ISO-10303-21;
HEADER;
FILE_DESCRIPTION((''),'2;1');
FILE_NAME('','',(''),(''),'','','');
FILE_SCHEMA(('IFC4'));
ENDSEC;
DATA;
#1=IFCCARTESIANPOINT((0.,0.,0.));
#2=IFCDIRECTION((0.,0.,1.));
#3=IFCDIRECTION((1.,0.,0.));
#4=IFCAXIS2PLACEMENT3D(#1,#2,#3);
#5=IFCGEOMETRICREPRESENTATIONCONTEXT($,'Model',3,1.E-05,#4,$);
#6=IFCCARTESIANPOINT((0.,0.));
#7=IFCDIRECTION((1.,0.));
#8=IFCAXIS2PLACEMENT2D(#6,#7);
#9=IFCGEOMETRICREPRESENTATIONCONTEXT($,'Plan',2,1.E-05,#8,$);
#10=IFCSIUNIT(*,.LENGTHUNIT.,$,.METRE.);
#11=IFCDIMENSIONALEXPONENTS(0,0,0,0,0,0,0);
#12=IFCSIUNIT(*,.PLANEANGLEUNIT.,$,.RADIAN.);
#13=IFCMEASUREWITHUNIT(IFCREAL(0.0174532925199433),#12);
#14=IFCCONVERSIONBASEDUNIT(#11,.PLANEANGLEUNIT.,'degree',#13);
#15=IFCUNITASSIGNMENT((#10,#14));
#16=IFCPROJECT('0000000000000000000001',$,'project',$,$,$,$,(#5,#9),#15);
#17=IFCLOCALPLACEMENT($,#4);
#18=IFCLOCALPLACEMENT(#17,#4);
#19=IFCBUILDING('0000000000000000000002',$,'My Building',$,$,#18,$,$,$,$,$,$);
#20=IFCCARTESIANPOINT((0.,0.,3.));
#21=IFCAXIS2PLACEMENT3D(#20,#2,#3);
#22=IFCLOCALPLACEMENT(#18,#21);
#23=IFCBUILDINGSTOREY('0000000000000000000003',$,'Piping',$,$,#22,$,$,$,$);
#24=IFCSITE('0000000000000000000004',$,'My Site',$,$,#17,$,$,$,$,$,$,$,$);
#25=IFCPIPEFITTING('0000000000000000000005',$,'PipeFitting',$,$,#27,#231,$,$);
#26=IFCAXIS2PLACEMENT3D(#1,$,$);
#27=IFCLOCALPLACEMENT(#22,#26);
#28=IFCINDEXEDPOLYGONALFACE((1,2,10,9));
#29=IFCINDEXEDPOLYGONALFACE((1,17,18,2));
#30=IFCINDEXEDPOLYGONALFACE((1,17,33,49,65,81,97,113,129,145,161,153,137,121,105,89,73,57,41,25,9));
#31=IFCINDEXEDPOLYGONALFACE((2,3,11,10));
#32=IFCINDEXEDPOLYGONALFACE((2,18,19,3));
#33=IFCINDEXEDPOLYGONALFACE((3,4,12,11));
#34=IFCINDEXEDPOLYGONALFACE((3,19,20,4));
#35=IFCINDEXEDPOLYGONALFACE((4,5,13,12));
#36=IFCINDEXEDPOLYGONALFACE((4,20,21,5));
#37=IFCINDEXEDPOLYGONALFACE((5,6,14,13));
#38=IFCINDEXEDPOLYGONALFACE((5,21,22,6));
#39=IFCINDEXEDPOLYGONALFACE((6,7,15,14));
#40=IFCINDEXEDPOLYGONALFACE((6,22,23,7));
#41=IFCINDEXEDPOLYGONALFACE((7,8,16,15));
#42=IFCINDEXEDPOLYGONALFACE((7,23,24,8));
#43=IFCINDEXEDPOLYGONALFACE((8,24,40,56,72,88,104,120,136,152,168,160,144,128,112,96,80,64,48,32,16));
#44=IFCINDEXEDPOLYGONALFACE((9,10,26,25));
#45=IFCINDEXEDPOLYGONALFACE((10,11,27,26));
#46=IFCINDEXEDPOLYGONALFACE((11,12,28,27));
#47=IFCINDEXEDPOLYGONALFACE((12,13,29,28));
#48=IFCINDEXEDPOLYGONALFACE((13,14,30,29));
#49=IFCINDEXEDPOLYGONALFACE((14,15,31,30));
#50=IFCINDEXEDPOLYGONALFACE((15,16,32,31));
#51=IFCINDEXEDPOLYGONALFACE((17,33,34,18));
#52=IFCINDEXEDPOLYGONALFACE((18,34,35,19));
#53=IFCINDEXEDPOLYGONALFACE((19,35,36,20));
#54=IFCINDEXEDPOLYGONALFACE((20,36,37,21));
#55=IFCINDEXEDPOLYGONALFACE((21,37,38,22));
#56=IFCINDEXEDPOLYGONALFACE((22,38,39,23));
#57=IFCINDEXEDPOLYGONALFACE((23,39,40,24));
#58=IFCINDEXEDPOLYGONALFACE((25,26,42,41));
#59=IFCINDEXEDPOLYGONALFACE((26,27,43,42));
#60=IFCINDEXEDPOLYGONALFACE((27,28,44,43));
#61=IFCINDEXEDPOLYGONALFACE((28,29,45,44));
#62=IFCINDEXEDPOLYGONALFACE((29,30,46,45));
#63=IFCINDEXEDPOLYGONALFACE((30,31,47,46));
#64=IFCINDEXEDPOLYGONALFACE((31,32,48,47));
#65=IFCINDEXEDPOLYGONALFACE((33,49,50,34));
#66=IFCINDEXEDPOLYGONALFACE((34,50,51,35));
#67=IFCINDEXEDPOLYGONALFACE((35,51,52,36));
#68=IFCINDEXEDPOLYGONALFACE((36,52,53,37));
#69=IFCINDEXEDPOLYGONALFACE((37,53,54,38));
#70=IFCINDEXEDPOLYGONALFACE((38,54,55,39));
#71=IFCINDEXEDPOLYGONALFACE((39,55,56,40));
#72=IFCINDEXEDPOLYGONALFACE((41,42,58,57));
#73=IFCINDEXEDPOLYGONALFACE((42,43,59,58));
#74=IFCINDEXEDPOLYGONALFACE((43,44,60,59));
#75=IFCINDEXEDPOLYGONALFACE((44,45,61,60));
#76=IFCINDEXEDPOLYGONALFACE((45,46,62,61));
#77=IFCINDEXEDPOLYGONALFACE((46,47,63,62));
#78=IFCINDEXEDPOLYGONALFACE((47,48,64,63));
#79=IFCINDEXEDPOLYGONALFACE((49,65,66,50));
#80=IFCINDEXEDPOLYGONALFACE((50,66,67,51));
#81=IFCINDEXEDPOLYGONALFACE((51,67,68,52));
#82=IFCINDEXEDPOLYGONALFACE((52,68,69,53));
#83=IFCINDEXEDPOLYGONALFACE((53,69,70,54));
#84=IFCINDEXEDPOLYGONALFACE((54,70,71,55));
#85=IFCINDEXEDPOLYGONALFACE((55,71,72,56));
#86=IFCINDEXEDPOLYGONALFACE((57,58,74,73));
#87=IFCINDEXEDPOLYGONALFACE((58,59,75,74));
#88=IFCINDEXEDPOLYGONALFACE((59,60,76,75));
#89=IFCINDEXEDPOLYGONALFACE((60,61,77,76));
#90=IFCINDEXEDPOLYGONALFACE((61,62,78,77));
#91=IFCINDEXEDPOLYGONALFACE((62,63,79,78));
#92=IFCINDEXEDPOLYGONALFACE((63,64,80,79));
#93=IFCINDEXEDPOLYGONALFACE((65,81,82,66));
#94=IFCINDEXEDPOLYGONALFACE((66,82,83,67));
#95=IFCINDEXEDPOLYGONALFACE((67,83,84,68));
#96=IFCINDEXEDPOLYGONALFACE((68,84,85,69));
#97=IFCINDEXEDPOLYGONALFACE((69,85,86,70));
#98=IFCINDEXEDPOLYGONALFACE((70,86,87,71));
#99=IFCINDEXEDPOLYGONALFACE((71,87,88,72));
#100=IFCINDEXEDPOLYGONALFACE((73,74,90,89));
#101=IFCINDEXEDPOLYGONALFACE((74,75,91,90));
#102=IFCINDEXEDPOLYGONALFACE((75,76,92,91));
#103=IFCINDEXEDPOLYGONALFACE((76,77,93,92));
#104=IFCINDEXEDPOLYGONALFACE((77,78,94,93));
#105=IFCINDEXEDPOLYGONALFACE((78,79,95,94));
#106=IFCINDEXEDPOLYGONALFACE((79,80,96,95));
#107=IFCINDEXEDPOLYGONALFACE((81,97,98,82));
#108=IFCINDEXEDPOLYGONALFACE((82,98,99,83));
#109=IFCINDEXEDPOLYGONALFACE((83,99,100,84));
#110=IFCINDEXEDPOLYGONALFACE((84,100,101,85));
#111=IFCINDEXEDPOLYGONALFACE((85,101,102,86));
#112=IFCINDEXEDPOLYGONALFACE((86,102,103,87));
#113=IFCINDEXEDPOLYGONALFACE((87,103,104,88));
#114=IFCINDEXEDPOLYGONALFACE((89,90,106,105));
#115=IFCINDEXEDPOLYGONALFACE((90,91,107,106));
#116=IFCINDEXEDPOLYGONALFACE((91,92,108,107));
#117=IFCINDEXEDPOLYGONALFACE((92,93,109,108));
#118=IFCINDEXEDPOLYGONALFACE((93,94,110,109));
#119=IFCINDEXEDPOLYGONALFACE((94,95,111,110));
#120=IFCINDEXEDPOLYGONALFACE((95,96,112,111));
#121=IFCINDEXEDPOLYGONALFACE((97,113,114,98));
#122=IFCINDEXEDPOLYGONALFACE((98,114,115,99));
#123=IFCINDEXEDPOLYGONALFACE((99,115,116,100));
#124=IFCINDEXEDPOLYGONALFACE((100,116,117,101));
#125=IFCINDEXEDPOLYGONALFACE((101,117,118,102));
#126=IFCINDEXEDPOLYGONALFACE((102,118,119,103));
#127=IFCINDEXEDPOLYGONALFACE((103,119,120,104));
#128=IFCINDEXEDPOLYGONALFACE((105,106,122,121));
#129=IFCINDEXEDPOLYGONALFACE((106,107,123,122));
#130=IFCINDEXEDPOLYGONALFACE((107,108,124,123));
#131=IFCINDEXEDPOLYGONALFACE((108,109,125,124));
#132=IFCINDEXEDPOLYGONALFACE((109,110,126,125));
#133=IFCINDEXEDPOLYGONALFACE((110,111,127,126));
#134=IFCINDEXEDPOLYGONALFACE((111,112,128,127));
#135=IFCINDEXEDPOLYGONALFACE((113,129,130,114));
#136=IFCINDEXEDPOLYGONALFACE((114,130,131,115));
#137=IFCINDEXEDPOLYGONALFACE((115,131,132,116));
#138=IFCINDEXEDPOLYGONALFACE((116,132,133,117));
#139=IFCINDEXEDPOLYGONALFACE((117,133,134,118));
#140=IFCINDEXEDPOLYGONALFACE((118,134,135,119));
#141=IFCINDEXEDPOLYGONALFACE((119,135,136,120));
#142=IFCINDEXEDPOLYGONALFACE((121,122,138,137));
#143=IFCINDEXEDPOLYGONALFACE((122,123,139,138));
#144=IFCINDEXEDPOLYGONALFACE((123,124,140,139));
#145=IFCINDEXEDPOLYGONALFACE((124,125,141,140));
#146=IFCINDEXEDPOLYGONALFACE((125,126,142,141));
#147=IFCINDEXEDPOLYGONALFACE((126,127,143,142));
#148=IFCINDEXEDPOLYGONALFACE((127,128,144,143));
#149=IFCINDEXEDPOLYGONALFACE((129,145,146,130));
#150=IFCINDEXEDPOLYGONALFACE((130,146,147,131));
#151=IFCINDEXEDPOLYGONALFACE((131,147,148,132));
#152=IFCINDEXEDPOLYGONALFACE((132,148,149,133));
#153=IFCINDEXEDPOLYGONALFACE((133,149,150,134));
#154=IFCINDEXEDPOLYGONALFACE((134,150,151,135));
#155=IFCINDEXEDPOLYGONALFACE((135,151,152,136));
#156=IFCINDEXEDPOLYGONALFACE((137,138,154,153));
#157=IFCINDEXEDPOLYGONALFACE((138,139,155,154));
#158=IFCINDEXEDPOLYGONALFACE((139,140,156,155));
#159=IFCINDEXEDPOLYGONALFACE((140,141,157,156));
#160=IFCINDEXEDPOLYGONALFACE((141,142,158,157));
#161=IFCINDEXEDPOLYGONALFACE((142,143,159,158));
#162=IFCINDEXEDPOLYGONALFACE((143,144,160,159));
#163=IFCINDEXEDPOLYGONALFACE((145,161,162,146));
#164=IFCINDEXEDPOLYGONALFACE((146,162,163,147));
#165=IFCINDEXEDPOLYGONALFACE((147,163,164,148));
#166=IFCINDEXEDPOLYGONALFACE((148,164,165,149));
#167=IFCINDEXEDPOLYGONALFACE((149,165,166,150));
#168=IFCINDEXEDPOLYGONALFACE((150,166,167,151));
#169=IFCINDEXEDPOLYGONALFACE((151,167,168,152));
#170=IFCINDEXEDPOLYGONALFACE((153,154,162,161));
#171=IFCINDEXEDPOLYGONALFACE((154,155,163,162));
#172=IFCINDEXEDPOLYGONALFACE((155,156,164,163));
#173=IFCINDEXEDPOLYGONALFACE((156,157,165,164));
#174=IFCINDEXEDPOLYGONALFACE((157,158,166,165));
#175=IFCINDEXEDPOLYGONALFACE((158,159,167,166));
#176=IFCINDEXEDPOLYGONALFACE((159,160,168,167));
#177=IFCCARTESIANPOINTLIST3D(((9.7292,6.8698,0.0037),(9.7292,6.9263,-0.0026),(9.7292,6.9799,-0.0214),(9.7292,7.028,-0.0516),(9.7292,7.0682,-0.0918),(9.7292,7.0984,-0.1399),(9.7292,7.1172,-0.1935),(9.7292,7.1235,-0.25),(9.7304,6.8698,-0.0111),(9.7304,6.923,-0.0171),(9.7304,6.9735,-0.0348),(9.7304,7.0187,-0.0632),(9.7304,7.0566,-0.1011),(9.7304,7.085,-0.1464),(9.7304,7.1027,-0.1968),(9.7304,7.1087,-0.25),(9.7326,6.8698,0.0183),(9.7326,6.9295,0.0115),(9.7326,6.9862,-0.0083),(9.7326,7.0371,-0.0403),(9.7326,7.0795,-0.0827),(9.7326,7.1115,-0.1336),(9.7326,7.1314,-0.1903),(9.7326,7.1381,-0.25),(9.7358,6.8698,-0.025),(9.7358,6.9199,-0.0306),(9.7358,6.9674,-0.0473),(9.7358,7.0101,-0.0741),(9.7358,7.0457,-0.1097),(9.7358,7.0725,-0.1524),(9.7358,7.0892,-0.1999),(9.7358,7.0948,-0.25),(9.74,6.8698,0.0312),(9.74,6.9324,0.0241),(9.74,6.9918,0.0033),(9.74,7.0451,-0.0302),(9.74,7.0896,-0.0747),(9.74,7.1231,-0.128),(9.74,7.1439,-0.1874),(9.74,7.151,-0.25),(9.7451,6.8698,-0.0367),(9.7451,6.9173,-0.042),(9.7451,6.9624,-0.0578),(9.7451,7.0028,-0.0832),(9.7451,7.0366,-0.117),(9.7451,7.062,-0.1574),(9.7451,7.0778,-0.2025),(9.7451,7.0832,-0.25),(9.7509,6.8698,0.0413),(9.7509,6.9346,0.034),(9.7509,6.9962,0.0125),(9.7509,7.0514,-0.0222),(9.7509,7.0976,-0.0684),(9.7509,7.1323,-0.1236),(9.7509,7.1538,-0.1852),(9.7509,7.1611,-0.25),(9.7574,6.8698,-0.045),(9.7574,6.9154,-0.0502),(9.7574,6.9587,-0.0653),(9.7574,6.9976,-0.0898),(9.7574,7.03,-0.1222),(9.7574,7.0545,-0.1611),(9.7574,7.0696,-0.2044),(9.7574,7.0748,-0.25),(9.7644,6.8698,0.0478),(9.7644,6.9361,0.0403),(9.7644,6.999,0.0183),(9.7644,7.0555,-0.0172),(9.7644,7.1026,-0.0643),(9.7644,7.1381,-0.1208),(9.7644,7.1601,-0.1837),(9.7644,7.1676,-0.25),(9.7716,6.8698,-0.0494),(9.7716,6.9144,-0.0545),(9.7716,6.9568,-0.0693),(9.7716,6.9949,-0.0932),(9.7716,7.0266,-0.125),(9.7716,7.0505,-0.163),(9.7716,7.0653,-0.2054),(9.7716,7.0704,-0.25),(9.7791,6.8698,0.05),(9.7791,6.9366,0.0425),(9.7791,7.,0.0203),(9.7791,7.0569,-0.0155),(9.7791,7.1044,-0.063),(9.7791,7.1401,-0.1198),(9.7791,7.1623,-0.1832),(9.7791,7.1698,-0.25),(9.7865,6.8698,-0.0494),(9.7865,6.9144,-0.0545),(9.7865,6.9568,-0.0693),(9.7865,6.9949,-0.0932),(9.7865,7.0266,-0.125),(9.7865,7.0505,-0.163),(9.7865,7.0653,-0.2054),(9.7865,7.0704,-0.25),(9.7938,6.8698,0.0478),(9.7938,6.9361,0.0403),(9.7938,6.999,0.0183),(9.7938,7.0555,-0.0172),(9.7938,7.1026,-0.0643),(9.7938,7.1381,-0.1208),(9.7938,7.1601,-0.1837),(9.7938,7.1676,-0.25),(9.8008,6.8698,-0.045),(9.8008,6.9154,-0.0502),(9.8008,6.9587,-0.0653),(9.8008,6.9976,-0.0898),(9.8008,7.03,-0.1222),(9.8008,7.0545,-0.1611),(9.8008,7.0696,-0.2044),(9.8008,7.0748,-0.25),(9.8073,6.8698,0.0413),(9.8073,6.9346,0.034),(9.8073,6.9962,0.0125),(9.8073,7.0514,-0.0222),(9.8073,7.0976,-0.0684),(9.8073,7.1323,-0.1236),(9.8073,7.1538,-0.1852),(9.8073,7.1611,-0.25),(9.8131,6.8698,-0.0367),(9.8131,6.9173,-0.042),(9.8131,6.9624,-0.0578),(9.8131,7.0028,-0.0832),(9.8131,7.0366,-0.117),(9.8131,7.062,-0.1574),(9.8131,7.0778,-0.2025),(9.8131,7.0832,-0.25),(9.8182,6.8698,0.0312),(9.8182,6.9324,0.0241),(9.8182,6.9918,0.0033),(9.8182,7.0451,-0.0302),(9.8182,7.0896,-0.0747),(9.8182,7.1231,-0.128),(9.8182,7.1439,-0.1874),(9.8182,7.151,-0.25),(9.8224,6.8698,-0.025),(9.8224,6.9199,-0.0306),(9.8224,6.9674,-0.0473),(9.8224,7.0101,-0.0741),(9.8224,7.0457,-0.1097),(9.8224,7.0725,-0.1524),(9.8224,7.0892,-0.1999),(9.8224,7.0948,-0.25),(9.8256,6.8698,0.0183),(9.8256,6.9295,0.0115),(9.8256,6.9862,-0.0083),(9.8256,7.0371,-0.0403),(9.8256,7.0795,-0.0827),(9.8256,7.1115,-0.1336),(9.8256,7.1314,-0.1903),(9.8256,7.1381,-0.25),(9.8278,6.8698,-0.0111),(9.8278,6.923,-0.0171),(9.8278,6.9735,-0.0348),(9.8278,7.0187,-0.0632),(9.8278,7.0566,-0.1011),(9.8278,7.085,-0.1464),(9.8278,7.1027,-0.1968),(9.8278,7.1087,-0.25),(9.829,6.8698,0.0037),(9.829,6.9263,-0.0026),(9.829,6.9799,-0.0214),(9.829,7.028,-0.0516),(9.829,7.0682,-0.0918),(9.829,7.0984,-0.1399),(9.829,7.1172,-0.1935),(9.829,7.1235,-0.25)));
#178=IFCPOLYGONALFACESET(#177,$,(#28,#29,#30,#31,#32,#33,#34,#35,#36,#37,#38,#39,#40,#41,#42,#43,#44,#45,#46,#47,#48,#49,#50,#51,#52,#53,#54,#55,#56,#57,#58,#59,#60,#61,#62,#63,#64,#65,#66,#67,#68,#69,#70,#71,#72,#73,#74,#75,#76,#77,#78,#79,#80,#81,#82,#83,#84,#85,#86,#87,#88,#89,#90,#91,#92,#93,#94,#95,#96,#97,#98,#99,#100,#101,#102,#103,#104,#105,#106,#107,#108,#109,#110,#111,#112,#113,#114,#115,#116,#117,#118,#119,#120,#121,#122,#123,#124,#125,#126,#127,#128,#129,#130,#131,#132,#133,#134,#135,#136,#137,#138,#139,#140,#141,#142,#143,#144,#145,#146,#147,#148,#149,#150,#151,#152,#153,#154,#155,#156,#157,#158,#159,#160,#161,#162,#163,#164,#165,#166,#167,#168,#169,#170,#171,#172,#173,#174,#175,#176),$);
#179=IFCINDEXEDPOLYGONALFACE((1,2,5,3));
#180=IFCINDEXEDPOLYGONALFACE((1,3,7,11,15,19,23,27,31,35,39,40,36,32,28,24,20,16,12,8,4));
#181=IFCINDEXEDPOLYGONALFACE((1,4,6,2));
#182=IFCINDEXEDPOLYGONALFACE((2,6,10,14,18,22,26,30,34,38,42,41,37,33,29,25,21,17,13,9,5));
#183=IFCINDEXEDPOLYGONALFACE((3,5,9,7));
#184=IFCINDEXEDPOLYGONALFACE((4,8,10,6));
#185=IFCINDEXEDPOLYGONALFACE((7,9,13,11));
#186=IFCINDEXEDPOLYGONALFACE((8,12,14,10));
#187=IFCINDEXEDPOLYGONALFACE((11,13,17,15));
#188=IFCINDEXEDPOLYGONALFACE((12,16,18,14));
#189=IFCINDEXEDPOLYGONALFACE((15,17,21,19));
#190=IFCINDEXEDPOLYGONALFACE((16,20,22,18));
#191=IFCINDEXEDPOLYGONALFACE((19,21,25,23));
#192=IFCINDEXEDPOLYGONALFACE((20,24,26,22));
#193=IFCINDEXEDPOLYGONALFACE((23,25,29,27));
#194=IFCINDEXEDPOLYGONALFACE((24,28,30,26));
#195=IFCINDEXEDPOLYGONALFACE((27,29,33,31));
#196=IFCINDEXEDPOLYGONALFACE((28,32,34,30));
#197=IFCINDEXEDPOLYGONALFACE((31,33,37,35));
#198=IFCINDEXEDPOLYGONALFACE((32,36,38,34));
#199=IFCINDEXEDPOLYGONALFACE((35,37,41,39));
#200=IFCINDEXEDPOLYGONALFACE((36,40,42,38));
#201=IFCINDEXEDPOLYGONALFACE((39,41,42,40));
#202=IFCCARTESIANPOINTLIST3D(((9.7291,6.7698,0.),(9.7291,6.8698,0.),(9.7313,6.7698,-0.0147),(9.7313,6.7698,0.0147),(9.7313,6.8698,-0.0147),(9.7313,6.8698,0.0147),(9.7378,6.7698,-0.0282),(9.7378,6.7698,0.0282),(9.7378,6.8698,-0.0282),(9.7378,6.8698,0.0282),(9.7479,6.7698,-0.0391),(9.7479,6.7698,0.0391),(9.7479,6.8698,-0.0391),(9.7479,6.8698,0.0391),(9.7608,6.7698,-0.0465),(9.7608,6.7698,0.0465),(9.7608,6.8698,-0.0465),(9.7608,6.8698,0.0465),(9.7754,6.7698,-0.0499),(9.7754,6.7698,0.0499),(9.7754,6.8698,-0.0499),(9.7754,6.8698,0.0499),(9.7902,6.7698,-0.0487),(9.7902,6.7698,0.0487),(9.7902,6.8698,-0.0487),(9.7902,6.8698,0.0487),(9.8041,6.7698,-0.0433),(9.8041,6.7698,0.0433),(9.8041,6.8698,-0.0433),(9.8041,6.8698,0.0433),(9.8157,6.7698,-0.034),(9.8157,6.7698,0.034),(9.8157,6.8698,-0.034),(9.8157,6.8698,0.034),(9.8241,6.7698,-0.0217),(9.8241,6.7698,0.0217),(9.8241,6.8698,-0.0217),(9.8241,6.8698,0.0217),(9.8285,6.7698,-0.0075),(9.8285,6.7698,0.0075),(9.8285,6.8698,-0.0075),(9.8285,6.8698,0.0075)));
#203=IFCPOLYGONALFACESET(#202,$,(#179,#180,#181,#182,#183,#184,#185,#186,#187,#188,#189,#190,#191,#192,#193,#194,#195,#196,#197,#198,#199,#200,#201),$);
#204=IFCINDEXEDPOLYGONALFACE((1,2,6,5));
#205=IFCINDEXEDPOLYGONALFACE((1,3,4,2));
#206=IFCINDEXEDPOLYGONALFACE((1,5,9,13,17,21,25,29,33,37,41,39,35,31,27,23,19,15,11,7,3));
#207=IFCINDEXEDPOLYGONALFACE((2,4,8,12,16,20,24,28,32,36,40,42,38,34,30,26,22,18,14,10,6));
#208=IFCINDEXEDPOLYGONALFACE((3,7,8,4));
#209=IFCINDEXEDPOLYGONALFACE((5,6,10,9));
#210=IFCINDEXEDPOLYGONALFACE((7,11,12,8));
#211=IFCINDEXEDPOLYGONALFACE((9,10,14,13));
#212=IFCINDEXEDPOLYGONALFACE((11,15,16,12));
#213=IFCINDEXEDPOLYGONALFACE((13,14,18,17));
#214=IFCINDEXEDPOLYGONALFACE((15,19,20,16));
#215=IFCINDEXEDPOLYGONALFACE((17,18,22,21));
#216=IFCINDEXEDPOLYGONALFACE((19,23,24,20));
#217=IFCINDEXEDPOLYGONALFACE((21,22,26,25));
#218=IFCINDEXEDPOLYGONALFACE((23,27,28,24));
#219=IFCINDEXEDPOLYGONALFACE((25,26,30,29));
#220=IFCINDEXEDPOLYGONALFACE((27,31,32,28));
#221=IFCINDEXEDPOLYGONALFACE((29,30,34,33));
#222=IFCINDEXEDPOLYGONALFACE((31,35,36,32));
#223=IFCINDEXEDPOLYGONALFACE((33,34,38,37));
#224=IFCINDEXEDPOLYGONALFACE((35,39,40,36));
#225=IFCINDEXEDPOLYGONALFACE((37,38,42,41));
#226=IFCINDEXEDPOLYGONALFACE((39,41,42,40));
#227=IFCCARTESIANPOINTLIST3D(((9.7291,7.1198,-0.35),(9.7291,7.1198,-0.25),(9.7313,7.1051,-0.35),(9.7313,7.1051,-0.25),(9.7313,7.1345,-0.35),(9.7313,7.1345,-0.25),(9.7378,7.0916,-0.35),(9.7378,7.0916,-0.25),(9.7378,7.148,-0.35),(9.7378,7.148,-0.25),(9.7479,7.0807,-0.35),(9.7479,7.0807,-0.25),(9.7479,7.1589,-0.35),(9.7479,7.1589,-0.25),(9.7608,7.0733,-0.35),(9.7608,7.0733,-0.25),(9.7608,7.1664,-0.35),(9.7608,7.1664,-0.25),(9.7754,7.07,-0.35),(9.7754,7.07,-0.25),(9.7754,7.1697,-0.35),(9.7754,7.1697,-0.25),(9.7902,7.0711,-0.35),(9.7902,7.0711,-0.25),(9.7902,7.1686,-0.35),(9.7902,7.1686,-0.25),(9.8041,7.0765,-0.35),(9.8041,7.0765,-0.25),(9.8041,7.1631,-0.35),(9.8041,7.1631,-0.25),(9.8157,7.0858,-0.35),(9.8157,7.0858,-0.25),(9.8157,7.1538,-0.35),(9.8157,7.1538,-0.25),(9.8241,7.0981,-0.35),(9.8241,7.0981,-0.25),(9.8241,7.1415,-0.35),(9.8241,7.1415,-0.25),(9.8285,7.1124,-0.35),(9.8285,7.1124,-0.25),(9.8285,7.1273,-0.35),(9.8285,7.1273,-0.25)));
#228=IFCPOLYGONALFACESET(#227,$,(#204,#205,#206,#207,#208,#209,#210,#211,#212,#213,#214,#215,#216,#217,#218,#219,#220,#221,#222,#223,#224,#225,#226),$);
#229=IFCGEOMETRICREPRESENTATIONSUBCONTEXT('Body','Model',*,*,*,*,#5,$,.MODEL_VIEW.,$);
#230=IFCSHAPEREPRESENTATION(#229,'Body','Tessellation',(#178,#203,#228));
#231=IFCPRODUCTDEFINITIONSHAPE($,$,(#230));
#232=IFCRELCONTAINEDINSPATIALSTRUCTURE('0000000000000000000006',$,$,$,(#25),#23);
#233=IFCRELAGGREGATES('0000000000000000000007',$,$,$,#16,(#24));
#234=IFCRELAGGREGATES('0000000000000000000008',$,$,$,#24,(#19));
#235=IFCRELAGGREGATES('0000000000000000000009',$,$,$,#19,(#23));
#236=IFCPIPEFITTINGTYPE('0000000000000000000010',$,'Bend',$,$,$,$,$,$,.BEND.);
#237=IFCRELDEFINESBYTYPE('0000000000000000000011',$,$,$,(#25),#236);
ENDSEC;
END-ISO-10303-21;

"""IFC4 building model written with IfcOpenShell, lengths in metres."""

from ifc_helpers import new_model, entity, si_unit, converted_unit, frame, origin_with_axes, origin_2d_with_axis, place, context, subcontext, project, spatial, line, indexed_curve, circle, outline, extrude, source, transform, mapped, type_object, type_shapes, element, save


model = new_model("IFC4")

# Units and contexts
model_context = context("Model", 3, precision=1e-05, world=origin_with_axes())
plan_context = context("Plan", 2, precision=1e-05, world=origin_2d_with_axis())
body_context = subcontext(model_context, "Body", "Model", "MODEL_VIEW")
ifc_project = project(units=[si_unit("LENGTHUNIT", "METRE"), converted_unit("PLANEANGLEUNIT", "degree", entity("IfcReal", 0.0174532925199433), si_unit("PLANEANGLEUNIT", "RADIAN"), dimensions=[0, 0, 0, 0, 0, 0, 0])], contexts=[model_context, plan_context])

# Site, building, storey
site_placement = place(None, origin_with_axes())
site = spatial("IfcSite", under=ifc_project, at=site_placement, Name="My Site")
building_placement = place(site_placement, origin_with_axes())
building = spatial("IfcBuilding", under=site, at=building_placement, Name="My Building")
storey_placement = place(building_placement, frame((0.0, 0.0, 3.0), z_axis=(0.0, 0.0, 1.0), x_axis=(1.0, 0.0, 0.0)))
storey = spatial("IfcBuildingStorey", under=building, at=storey_placement, Name="Piping")

# Pipe fitting, opening
pipe_fitting_type = type_object("IfcPipeFittingType", Name="Bend", PredefinedType="BEND")
shared_shape = source(origin_with_axes(), body_context, "Body", "SolidModel", [
    entity("IfcSweptDiskSolid", entity("IfcIndexedPolyCurve", entity("IfcCartesianPointList3D", [[0.0, 0.0, 0.1], [0.0, -0.0732, 0.2768], [0.0, -0.25, 0.35]]), [entity("IfcArcIndex", [1, 2, 3])]), 0.05),
    extrude(circle(Radius=0.05), origin_with_axes(), (0.0, 0.0, 1.0), 0.1),
    extrude(circle(Radius=0.05), frame((0.0, -0.25, 0.35), z_axis=(0.0, -1.0, 0.0), x_axis=(1.0, 0.0, 0.0)), (0.0, 0.0, 1.0), 0.1),
])
type_shapes(pipe_fitting_type, [shared_shape])
pipe_fitting_1_placement = place(storey_placement, frame((9.7791, 6.7698, 0.0), z_axis=(0.0, 1.0, 0.0), x_axis=(-1.0, 0.0, 0.0)))
pipe_fitting_1 = element("IfcPipeFitting", 1, at=pipe_fitting_1_placement, inside=storey, type_object=pipe_fitting_type, Name="PipeFitting", context=body_context, shape_type="MappedRepresentation", body=[
    mapped(shared_shape, transform((0.0, 0.0, 0.0), x_axis=(1.0, 0.0, 0.0), y_axis=(0.0, 1.0, 0.0), z_axis=(0.0, 0.0, 1.0), scale=1.0)),
])
opening_1_placement = place(pipe_fitting_1_placement, frame((9.7791, -3.0, -6.7698), z_axis=(0.0, 1.0, 0.0), x_axis=(-1.0, 0.0, 0.0)))
element("IfcOpeningElement", 2, at=opening_1_placement, cuts=pipe_fitting_1, PredefinedType="OPENING", context=body_context, shape_type="SweptSolid", body=[
    extrude(outline(indexed_curve([(0.0, 0.0), (0.5, 0.0), (0.5, 0.5), (0.0, 0.5)], segments=[line(1, 2, 3, 4, 1)])), origin_with_axes(), (0.0, 0.0, 1.0), 0.5),
])

save(model, "model.ifc")
